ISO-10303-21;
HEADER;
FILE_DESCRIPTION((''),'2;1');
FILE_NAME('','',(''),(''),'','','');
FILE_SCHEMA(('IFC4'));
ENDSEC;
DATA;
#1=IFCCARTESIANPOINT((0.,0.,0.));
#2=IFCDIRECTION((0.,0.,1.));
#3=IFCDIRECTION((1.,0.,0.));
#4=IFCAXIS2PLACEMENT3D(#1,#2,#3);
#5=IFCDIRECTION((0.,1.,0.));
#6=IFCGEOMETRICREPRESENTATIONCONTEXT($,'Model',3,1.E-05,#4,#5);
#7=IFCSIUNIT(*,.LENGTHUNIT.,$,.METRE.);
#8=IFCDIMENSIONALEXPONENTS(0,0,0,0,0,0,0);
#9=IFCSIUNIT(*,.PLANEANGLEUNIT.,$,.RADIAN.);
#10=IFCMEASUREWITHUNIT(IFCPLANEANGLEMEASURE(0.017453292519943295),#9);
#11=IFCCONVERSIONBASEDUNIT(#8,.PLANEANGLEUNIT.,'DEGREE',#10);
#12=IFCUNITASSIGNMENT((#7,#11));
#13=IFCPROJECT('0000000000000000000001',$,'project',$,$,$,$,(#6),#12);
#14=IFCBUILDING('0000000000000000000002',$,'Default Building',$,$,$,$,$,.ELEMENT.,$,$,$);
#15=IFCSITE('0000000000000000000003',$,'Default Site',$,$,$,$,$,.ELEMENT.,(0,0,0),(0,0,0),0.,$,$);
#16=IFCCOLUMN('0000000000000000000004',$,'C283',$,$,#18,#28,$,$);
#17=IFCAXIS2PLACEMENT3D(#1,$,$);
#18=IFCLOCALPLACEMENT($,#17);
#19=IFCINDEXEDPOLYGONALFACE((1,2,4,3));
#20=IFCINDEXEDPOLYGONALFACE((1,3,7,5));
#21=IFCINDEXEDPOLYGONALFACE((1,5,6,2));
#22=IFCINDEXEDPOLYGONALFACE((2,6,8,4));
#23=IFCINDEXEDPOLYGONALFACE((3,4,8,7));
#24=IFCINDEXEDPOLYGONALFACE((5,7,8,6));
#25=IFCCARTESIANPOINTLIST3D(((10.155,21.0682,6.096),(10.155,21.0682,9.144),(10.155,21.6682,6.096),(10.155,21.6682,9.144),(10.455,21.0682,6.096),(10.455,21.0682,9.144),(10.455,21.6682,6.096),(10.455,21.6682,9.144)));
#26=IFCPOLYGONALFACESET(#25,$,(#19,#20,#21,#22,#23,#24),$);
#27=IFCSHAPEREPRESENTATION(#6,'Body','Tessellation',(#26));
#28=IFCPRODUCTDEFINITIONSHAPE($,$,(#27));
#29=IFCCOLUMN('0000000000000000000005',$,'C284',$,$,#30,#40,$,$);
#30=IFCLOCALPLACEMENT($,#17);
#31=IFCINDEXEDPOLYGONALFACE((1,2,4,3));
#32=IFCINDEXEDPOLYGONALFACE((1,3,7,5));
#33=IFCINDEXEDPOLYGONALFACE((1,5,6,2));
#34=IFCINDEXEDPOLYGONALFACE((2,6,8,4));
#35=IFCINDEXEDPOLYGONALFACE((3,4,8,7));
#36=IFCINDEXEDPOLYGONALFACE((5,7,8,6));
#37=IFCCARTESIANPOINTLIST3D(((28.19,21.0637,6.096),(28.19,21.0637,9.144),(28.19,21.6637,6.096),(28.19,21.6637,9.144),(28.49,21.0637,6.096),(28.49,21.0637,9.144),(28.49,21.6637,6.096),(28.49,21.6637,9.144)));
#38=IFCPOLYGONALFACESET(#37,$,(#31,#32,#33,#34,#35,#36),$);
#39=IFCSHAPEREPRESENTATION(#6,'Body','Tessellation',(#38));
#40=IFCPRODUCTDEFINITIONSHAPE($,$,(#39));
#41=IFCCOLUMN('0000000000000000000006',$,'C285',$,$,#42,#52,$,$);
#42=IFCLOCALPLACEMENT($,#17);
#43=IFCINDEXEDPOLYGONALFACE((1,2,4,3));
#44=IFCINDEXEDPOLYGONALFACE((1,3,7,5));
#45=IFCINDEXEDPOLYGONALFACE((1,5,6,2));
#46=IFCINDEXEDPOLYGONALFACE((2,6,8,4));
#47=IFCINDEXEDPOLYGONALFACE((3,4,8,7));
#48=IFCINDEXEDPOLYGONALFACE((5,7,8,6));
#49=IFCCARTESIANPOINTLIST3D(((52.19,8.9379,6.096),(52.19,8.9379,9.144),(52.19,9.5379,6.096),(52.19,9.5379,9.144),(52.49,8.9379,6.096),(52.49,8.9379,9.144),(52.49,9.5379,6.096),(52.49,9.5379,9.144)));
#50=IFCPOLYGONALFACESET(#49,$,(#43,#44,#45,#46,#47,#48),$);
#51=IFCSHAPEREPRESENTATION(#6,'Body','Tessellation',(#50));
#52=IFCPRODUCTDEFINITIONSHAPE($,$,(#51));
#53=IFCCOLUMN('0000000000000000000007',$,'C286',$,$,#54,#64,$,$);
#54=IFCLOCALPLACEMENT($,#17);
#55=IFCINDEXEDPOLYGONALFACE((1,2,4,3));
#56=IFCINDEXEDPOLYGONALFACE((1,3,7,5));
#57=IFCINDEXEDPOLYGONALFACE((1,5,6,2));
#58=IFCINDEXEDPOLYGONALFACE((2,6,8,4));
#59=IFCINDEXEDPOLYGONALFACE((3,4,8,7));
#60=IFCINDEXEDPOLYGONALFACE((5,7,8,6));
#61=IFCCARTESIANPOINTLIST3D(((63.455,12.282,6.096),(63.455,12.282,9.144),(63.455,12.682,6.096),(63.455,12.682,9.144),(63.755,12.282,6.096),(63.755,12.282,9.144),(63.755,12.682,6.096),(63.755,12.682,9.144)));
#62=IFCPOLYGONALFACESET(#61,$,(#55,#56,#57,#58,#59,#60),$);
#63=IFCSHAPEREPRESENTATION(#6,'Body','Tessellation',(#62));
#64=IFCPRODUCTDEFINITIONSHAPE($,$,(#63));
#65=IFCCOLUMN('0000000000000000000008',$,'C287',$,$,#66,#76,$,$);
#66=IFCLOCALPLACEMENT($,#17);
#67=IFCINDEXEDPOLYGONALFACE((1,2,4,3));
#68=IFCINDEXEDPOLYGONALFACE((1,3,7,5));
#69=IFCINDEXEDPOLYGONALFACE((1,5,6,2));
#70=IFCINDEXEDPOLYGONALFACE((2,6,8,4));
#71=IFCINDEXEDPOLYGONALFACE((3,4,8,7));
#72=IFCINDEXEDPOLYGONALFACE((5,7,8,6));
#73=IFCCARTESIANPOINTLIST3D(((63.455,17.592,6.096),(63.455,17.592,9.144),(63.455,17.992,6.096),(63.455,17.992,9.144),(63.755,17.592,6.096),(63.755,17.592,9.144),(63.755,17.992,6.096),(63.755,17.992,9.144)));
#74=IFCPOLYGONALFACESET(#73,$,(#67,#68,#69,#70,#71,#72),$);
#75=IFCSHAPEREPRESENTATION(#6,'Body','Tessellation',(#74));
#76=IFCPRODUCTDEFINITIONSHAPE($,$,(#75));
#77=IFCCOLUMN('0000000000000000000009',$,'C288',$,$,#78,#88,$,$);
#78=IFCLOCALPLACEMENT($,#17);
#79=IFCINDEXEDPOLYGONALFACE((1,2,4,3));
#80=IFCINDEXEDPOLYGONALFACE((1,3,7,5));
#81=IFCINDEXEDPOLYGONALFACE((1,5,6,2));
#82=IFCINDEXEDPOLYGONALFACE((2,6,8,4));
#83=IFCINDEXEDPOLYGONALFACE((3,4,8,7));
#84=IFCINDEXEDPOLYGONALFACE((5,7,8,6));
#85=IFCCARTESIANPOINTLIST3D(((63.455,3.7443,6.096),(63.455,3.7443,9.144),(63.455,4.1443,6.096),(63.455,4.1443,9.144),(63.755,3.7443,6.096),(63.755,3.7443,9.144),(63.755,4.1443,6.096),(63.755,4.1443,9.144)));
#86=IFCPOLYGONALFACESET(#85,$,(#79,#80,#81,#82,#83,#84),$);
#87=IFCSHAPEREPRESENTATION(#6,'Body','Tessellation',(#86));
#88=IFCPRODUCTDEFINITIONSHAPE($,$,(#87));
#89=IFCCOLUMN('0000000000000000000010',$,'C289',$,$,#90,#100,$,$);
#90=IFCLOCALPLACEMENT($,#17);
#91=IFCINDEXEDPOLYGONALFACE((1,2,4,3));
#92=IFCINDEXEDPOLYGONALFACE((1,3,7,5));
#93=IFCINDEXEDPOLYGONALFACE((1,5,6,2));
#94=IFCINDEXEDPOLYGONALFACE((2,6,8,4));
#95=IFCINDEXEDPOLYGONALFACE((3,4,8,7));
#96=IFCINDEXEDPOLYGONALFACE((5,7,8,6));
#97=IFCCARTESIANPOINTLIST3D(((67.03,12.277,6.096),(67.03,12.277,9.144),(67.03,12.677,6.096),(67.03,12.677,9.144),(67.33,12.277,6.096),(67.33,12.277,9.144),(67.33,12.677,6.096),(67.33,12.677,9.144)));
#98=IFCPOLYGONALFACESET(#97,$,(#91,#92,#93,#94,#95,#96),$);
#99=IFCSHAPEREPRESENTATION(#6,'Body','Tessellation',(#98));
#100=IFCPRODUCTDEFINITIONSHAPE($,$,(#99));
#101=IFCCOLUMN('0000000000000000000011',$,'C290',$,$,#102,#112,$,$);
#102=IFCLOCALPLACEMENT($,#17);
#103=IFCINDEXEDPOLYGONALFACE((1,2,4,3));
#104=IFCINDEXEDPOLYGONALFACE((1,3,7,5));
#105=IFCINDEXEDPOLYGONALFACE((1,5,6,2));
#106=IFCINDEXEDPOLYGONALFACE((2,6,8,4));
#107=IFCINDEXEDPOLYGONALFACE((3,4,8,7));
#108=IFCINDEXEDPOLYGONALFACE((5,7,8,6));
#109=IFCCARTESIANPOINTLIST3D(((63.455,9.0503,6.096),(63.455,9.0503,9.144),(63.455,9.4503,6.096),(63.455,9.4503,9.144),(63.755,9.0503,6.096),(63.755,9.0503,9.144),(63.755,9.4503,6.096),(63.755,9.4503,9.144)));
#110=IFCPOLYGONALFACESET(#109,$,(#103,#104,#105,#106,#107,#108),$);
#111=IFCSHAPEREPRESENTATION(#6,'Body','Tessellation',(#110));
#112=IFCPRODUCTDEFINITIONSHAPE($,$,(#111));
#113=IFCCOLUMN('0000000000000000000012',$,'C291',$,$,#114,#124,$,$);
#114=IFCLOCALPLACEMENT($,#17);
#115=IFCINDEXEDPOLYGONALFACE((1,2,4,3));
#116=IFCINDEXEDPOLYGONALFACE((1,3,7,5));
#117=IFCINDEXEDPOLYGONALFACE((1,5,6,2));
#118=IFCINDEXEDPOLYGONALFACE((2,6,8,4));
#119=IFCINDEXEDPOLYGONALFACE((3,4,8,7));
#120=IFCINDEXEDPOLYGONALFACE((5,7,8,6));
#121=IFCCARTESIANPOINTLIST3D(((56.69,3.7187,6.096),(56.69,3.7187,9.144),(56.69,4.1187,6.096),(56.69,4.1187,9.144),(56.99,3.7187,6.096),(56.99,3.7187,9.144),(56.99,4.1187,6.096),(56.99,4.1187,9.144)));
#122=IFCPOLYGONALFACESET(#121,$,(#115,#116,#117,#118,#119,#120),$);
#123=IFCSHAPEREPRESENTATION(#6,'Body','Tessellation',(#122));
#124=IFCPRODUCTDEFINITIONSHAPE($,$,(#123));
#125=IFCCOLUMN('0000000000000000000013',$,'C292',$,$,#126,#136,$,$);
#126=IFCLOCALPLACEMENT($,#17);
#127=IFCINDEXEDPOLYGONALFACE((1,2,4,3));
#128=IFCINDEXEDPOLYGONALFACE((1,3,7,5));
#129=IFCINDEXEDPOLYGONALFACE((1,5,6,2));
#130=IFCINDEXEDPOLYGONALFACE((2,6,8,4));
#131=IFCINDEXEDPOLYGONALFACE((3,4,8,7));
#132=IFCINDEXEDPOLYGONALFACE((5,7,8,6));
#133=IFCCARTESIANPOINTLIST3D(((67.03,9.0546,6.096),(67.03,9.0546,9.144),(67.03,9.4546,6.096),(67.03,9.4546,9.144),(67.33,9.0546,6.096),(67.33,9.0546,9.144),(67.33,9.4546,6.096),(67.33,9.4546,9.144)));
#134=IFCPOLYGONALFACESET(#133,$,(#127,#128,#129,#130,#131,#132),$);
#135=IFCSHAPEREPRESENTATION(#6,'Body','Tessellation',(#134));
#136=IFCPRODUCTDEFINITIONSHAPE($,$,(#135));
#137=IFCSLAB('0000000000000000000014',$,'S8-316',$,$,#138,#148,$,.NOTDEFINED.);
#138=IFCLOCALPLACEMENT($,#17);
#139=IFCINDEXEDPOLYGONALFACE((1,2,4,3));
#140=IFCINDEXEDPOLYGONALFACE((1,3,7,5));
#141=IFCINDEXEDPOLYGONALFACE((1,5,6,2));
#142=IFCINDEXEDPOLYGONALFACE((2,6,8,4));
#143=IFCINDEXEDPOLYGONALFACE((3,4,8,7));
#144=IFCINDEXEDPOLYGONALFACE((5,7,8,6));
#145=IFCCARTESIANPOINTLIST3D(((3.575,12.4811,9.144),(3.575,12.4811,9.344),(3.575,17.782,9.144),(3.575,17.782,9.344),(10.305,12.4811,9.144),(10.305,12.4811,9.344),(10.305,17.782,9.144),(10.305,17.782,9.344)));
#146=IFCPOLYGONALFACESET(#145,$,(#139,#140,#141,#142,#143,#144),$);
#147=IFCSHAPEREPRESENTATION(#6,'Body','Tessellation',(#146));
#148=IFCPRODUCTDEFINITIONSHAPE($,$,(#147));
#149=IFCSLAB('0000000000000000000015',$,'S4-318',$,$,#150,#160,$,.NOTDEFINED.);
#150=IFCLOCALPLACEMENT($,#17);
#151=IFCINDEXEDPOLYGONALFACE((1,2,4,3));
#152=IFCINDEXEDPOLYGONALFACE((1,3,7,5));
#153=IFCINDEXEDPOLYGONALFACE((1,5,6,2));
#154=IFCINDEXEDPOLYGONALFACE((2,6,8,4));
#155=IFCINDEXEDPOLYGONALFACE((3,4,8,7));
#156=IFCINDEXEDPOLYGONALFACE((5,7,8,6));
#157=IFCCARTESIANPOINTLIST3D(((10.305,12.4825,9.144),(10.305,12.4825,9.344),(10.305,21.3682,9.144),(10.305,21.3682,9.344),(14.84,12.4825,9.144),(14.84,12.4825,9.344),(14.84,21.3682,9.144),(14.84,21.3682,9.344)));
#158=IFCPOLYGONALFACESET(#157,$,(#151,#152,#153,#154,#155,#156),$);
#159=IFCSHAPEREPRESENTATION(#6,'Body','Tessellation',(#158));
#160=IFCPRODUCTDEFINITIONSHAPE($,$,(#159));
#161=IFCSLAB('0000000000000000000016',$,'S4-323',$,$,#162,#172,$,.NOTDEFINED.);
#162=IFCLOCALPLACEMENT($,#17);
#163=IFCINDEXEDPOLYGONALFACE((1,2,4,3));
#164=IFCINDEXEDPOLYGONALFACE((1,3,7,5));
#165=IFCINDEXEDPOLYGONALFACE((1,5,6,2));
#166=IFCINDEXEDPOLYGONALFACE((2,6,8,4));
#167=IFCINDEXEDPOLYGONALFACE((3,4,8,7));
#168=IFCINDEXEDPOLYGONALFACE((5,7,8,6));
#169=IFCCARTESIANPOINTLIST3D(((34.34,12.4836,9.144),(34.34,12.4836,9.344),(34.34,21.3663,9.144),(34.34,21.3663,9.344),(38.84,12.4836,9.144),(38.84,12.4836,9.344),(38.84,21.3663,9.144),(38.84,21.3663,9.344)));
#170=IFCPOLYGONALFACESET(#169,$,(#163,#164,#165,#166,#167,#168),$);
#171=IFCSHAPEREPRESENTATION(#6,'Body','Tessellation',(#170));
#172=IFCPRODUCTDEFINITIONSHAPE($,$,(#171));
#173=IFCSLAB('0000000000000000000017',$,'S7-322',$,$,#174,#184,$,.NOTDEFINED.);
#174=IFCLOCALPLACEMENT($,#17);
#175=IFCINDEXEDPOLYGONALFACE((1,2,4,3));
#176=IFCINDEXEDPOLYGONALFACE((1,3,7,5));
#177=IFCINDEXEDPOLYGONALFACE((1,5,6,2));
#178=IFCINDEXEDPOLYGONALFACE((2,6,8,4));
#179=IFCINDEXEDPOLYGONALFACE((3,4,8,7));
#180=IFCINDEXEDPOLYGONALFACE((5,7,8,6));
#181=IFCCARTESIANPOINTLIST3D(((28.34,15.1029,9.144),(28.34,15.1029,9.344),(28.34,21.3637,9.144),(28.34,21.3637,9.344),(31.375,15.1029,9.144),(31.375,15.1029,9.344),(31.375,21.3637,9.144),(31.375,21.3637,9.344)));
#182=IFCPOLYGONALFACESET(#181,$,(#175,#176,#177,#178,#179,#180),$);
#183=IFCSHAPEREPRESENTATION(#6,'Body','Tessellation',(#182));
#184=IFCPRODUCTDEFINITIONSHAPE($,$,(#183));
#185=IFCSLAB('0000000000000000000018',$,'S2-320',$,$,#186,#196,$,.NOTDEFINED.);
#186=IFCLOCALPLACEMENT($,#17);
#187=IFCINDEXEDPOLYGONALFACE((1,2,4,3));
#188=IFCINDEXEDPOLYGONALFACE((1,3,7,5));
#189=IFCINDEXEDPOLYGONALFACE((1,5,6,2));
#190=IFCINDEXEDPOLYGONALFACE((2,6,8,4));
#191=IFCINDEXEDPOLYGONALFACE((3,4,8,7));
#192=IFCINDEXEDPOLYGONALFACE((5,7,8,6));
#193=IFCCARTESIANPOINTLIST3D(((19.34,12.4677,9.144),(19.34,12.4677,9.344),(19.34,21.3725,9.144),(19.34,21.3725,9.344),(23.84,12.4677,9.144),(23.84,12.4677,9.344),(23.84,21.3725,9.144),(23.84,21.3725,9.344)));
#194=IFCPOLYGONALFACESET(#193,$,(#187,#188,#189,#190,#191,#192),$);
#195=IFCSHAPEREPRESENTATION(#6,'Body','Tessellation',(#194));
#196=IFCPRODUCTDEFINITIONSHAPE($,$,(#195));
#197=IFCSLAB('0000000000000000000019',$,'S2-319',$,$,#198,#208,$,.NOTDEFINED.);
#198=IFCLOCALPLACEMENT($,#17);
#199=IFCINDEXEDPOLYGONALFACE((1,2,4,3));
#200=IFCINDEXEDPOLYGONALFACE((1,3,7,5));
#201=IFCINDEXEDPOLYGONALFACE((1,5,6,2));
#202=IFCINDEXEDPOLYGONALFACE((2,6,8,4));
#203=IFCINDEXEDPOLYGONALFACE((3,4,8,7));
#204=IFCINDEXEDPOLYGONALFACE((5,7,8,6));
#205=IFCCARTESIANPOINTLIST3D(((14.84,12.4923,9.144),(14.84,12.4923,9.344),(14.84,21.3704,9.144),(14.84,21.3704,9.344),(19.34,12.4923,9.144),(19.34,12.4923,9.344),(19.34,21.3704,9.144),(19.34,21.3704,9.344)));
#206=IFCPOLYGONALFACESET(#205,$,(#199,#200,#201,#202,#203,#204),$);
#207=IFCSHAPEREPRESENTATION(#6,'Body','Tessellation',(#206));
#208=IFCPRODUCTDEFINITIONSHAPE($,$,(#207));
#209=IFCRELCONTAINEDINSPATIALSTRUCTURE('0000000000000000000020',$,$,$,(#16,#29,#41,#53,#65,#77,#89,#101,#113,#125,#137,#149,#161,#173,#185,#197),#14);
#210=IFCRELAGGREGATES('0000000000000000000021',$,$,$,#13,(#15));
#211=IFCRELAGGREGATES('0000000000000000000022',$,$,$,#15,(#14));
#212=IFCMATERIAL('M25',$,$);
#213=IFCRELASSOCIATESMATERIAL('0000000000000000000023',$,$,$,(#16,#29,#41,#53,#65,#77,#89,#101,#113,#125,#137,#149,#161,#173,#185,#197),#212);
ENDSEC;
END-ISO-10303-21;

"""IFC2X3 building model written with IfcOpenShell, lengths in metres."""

from ifc_helpers import new_model, entity, si_unit, converted_unit, direction, frame, frame_2d, origin_with_axes, place, context, project, spatial, rectangle, extrude, material, element, save


model = new_model("IFC2X3")

# Units and contexts
model_context = context("Model", 3, precision=1e-05, world=origin_with_axes(), true_north=direction((0.0, 1.0, 0.0)))
ifc_project = project(units=[si_unit("LENGTHUNIT", "METRE"), converted_unit("PLANEANGLEUNIT", "DEGREE", entity("IfcPlaneAngleMeasure", 0.017453292519943295), si_unit("PLANEANGLEUNIT", "RADIAN"), dimensions=[0, 0, 0, 0, 0, 0, 0])], contexts=[model_context])

# Site, building
site = spatial("IfcSite", under=ifc_project, Name="Default Site", CompositionType="ELEMENT", RefLatitude=(0, 0, 0), RefLongitude=(0, 0, 0), RefElevation=0.0)
building = spatial("IfcBuilding", under=site, Name="Default Building", CompositionType="ELEMENT")

# Columns
ifc_material = material(Name="M25")
placement = place(None, origin_with_axes())
element("IfcColumn", 1, at=placement, inside=building, material=ifc_material, Name="C283", context=model_context, shape_type="SweptSolid", body=[
    extrude(rectangle(XDim=0.3, YDim=0.6, at=frame_2d((0.0, 0.0), x_axis=(1.0, 0.0, 0.0))), frame((10.305, 21.3682, 6.096), z_axis=(0.0, 0.0, 1.0), x_axis=(1.0, 0.0, 0.0)), (0.0, 0.0, 1.0), 3.048),
])
element("IfcColumn", 2, at=placement, inside=building, material=ifc_material, Name="C284", context=model_context, shape_type="SweptSolid", body=[
    extrude(rectangle(XDim=0.3, YDim=0.6, at=frame_2d((0.0, 0.0), x_axis=(1.0, 0.0, 0.0))), frame((28.34, 21.3637, 6.096), z_axis=(0.0, 0.0, 1.0), x_axis=(1.0, 0.0, 0.0)), (0.0, 0.0, 1.0), 3.048),
])
element("IfcColumn", 3, at=placement, inside=building, material=ifc_material, Name="C285", context=model_context, shape_type="SweptSolid", body=[
    extrude(rectangle(XDim=0.3, YDim=0.6, at=frame_2d((0.0, 0.0), x_axis=(1.0, 0.0, 0.0))), frame((52.34, 9.2379, 6.096), z_axis=(0.0, 0.0, 1.0), x_axis=(1.0, 0.0, 0.0)), (0.0, 0.0, 1.0), 3.048),
])
element("IfcColumn", 4, at=placement, inside=building, material=ifc_material, Name="C286", context=model_context, shape_type="SweptSolid", body=[
    extrude(rectangle(XDim=0.3, YDim=0.4, at=frame_2d((0.0, 0.0), x_axis=(1.0, 0.0, 0.0))), frame((63.605, 12.482, 6.096), z_axis=(0.0, 0.0, 1.0), x_axis=(1.0, 0.0, 0.0)), (0.0, 0.0, 1.0), 3.048),
])
element("IfcColumn", 5, at=placement, inside=building, material=ifc_material, Name="C287", context=model_context, shape_type="SweptSolid", body=[
    extrude(rectangle(XDim=0.3, YDim=0.4, at=frame_2d((0.0, 0.0), x_axis=(1.0, 0.0, 0.0))), frame((63.605, 17.792, 6.096), z_axis=(0.0, 0.0, 1.0), x_axis=(1.0, 0.0, 0.0)), (0.0, 0.0, 1.0), 3.048),
])
element("IfcColumn", 6, at=placement, inside=building, material=ifc_material, Name="C288", context=model_context, shape_type="SweptSolid", body=[
    extrude(rectangle(XDim=0.3, YDim=0.4, at=frame_2d((0.0, 0.0), x_axis=(1.0, 0.0, 0.0))), frame((63.605, 3.9443, 6.096), z_axis=(0.0, 0.0, 1.0), x_axis=(1.0, 0.0, 0.0)), (0.0, 0.0, 1.0), 3.048),
])
element("IfcColumn", 7, at=placement, inside=building, material=ifc_material, Name="C289", context=model_context, shape_type="SweptSolid", body=[
    extrude(rectangle(XDim=0.3, YDim=0.4, at=frame_2d((0.0, 0.0), x_axis=(1.0, 0.0, 0.0))), frame((67.18, 12.477, 6.096), z_axis=(0.0, 0.0, 1.0), x_axis=(1.0, 0.0, 0.0)), (0.0, 0.0, 1.0), 3.048),
])
element("IfcColumn", 8, at=placement, inside=building, material=ifc_material, Name="C290", context=model_context, shape_type="SweptSolid", body=[
    extrude(rectangle(XDim=0.3, YDim=0.4, at=frame_2d((0.0, 0.0), x_axis=(1.0, 0.0, 0.0))), frame((63.605, 9.2503, 6.096), z_axis=(0.0, 0.0, 1.0), x_axis=(1.0, 0.0, 0.0)), (0.0, 0.0, 1.0), 3.048),
])
element("IfcColumn", 9, at=placement, inside=building, material=ifc_material, Name="C291", context=model_context, shape_type="SweptSolid", body=[
    extrude(rectangle(XDim=0.3, YDim=0.4, at=frame_2d((0.0, 0.0), x_axis=(1.0, 0.0, 0.0))), frame((56.84, 3.9187, 6.096), z_axis=(0.0, 0.0, 1.0), x_axis=(1.0, 0.0, 0.0)), (0.0, 0.0, 1.0), 3.048),
])
element("IfcColumn", 10, at=placement, inside=building, material=ifc_material, Name="C292", context=model_context, shape_type="SweptSolid", body=[
    extrude(rectangle(XDim=0.3, YDim=0.4, at=frame_2d((0.0, 0.0), x_axis=(1.0, 0.0, 0.0))), frame((67.18, 9.2546, 6.096), z_axis=(0.0, 0.0, 1.0), x_axis=(1.0, 0.0, 0.0)), (0.0, 0.0, 1.0), 3.048),
])

# Slabs
element("IfcSlab", 11, at=placement, inside=building, material=ifc_material, Name="S8-316", PredefinedType="NOTDEFINED", context=model_context, shape_type="SweptSolid", body=[
    extrude(rectangle(XDim=6.73, YDim=5.3009, at=frame_2d((0.0, 0.0), x_axis=(1.0, 0.0, 0.0))), frame((6.94, 15.1315, 9.144), z_axis=(0.0, 0.0, 1.0), x_axis=(1.0, 0.0, 0.0)), (0.0, 0.0, 1.0), 0.2),
])
element("IfcSlab", 12, at=placement, inside=building, material=ifc_material, Name="S4-318", PredefinedType="NOTDEFINED", context=model_context, shape_type="SweptSolid", body=[
    extrude(rectangle(XDim=4.535, YDim=8.8857, at=frame_2d((0.0, 0.0), x_axis=(1.0, 0.0, 0.0))), frame((12.5725, 16.9253, 9.144), z_axis=(0.0, 0.0, 1.0), x_axis=(1.0, 0.0, 0.0)), (0.0, 0.0, 1.0), 0.2),
])
element("IfcSlab", 13, at=placement, inside=building, material=ifc_material, Name="S4-323", PredefinedType="NOTDEFINED", context=model_context, shape_type="SweptSolid", body=[
    extrude(rectangle(XDim=4.5, YDim=8.8827, at=frame_2d((0.0, 0.0), x_axis=(1.0, 0.0, 0.0))), frame((36.59, 16.925, 9.144), z_axis=(0.0, 0.0, 1.0), x_axis=(1.0, 0.0, 0.0)), (0.0, 0.0, 1.0), 0.2),
])
element("IfcSlab", 14, at=placement, inside=building, material=ifc_material, Name="S7-322", PredefinedType="NOTDEFINED", context=model_context, shape_type="SweptSolid", body=[
    extrude(rectangle(XDim=3.035, YDim=6.2608, at=frame_2d((0.0, 0.0), x_axis=(1.0, 0.0, 0.0))), frame((29.8575, 18.2333, 9.144), z_axis=(0.0, 0.0, 1.0), x_axis=(1.0, 0.0, 0.0)), (0.0, 0.0, 1.0), 0.2),
])
element("IfcSlab", 15, at=placement, inside=building, material=ifc_material, Name="S2-320", PredefinedType="NOTDEFINED", context=model_context, shape_type="SweptSolid", body=[
    extrude(rectangle(XDim=4.5, YDim=8.9048, at=frame_2d((0.0, 0.0), x_axis=(1.0, 0.0, 0.0))), frame((21.59, 16.9201, 9.144), z_axis=(0.0, 0.0, 1.0), x_axis=(1.0, 0.0, 0.0)), (0.0, 0.0, 1.0), 0.2),
])
element("IfcSlab", 16, at=placement, inside=building, material=ifc_material, Name="S2-319", PredefinedType="NOTDEFINED", context=model_context, shape_type="SweptSolid", body=[
    extrude(rectangle(XDim=4.5, YDim=8.8781, at=frame_2d((0.0, 0.0), x_axis=(1.0, 0.0, 0.0))), frame((17.09, 16.9313, 9.144), z_axis=(0.0, 0.0, 1.0), x_axis=(1.0, 0.0, 0.0)), (0.0, 0.0, 1.0), 0.2),
])

save(model, "model.ifc")
